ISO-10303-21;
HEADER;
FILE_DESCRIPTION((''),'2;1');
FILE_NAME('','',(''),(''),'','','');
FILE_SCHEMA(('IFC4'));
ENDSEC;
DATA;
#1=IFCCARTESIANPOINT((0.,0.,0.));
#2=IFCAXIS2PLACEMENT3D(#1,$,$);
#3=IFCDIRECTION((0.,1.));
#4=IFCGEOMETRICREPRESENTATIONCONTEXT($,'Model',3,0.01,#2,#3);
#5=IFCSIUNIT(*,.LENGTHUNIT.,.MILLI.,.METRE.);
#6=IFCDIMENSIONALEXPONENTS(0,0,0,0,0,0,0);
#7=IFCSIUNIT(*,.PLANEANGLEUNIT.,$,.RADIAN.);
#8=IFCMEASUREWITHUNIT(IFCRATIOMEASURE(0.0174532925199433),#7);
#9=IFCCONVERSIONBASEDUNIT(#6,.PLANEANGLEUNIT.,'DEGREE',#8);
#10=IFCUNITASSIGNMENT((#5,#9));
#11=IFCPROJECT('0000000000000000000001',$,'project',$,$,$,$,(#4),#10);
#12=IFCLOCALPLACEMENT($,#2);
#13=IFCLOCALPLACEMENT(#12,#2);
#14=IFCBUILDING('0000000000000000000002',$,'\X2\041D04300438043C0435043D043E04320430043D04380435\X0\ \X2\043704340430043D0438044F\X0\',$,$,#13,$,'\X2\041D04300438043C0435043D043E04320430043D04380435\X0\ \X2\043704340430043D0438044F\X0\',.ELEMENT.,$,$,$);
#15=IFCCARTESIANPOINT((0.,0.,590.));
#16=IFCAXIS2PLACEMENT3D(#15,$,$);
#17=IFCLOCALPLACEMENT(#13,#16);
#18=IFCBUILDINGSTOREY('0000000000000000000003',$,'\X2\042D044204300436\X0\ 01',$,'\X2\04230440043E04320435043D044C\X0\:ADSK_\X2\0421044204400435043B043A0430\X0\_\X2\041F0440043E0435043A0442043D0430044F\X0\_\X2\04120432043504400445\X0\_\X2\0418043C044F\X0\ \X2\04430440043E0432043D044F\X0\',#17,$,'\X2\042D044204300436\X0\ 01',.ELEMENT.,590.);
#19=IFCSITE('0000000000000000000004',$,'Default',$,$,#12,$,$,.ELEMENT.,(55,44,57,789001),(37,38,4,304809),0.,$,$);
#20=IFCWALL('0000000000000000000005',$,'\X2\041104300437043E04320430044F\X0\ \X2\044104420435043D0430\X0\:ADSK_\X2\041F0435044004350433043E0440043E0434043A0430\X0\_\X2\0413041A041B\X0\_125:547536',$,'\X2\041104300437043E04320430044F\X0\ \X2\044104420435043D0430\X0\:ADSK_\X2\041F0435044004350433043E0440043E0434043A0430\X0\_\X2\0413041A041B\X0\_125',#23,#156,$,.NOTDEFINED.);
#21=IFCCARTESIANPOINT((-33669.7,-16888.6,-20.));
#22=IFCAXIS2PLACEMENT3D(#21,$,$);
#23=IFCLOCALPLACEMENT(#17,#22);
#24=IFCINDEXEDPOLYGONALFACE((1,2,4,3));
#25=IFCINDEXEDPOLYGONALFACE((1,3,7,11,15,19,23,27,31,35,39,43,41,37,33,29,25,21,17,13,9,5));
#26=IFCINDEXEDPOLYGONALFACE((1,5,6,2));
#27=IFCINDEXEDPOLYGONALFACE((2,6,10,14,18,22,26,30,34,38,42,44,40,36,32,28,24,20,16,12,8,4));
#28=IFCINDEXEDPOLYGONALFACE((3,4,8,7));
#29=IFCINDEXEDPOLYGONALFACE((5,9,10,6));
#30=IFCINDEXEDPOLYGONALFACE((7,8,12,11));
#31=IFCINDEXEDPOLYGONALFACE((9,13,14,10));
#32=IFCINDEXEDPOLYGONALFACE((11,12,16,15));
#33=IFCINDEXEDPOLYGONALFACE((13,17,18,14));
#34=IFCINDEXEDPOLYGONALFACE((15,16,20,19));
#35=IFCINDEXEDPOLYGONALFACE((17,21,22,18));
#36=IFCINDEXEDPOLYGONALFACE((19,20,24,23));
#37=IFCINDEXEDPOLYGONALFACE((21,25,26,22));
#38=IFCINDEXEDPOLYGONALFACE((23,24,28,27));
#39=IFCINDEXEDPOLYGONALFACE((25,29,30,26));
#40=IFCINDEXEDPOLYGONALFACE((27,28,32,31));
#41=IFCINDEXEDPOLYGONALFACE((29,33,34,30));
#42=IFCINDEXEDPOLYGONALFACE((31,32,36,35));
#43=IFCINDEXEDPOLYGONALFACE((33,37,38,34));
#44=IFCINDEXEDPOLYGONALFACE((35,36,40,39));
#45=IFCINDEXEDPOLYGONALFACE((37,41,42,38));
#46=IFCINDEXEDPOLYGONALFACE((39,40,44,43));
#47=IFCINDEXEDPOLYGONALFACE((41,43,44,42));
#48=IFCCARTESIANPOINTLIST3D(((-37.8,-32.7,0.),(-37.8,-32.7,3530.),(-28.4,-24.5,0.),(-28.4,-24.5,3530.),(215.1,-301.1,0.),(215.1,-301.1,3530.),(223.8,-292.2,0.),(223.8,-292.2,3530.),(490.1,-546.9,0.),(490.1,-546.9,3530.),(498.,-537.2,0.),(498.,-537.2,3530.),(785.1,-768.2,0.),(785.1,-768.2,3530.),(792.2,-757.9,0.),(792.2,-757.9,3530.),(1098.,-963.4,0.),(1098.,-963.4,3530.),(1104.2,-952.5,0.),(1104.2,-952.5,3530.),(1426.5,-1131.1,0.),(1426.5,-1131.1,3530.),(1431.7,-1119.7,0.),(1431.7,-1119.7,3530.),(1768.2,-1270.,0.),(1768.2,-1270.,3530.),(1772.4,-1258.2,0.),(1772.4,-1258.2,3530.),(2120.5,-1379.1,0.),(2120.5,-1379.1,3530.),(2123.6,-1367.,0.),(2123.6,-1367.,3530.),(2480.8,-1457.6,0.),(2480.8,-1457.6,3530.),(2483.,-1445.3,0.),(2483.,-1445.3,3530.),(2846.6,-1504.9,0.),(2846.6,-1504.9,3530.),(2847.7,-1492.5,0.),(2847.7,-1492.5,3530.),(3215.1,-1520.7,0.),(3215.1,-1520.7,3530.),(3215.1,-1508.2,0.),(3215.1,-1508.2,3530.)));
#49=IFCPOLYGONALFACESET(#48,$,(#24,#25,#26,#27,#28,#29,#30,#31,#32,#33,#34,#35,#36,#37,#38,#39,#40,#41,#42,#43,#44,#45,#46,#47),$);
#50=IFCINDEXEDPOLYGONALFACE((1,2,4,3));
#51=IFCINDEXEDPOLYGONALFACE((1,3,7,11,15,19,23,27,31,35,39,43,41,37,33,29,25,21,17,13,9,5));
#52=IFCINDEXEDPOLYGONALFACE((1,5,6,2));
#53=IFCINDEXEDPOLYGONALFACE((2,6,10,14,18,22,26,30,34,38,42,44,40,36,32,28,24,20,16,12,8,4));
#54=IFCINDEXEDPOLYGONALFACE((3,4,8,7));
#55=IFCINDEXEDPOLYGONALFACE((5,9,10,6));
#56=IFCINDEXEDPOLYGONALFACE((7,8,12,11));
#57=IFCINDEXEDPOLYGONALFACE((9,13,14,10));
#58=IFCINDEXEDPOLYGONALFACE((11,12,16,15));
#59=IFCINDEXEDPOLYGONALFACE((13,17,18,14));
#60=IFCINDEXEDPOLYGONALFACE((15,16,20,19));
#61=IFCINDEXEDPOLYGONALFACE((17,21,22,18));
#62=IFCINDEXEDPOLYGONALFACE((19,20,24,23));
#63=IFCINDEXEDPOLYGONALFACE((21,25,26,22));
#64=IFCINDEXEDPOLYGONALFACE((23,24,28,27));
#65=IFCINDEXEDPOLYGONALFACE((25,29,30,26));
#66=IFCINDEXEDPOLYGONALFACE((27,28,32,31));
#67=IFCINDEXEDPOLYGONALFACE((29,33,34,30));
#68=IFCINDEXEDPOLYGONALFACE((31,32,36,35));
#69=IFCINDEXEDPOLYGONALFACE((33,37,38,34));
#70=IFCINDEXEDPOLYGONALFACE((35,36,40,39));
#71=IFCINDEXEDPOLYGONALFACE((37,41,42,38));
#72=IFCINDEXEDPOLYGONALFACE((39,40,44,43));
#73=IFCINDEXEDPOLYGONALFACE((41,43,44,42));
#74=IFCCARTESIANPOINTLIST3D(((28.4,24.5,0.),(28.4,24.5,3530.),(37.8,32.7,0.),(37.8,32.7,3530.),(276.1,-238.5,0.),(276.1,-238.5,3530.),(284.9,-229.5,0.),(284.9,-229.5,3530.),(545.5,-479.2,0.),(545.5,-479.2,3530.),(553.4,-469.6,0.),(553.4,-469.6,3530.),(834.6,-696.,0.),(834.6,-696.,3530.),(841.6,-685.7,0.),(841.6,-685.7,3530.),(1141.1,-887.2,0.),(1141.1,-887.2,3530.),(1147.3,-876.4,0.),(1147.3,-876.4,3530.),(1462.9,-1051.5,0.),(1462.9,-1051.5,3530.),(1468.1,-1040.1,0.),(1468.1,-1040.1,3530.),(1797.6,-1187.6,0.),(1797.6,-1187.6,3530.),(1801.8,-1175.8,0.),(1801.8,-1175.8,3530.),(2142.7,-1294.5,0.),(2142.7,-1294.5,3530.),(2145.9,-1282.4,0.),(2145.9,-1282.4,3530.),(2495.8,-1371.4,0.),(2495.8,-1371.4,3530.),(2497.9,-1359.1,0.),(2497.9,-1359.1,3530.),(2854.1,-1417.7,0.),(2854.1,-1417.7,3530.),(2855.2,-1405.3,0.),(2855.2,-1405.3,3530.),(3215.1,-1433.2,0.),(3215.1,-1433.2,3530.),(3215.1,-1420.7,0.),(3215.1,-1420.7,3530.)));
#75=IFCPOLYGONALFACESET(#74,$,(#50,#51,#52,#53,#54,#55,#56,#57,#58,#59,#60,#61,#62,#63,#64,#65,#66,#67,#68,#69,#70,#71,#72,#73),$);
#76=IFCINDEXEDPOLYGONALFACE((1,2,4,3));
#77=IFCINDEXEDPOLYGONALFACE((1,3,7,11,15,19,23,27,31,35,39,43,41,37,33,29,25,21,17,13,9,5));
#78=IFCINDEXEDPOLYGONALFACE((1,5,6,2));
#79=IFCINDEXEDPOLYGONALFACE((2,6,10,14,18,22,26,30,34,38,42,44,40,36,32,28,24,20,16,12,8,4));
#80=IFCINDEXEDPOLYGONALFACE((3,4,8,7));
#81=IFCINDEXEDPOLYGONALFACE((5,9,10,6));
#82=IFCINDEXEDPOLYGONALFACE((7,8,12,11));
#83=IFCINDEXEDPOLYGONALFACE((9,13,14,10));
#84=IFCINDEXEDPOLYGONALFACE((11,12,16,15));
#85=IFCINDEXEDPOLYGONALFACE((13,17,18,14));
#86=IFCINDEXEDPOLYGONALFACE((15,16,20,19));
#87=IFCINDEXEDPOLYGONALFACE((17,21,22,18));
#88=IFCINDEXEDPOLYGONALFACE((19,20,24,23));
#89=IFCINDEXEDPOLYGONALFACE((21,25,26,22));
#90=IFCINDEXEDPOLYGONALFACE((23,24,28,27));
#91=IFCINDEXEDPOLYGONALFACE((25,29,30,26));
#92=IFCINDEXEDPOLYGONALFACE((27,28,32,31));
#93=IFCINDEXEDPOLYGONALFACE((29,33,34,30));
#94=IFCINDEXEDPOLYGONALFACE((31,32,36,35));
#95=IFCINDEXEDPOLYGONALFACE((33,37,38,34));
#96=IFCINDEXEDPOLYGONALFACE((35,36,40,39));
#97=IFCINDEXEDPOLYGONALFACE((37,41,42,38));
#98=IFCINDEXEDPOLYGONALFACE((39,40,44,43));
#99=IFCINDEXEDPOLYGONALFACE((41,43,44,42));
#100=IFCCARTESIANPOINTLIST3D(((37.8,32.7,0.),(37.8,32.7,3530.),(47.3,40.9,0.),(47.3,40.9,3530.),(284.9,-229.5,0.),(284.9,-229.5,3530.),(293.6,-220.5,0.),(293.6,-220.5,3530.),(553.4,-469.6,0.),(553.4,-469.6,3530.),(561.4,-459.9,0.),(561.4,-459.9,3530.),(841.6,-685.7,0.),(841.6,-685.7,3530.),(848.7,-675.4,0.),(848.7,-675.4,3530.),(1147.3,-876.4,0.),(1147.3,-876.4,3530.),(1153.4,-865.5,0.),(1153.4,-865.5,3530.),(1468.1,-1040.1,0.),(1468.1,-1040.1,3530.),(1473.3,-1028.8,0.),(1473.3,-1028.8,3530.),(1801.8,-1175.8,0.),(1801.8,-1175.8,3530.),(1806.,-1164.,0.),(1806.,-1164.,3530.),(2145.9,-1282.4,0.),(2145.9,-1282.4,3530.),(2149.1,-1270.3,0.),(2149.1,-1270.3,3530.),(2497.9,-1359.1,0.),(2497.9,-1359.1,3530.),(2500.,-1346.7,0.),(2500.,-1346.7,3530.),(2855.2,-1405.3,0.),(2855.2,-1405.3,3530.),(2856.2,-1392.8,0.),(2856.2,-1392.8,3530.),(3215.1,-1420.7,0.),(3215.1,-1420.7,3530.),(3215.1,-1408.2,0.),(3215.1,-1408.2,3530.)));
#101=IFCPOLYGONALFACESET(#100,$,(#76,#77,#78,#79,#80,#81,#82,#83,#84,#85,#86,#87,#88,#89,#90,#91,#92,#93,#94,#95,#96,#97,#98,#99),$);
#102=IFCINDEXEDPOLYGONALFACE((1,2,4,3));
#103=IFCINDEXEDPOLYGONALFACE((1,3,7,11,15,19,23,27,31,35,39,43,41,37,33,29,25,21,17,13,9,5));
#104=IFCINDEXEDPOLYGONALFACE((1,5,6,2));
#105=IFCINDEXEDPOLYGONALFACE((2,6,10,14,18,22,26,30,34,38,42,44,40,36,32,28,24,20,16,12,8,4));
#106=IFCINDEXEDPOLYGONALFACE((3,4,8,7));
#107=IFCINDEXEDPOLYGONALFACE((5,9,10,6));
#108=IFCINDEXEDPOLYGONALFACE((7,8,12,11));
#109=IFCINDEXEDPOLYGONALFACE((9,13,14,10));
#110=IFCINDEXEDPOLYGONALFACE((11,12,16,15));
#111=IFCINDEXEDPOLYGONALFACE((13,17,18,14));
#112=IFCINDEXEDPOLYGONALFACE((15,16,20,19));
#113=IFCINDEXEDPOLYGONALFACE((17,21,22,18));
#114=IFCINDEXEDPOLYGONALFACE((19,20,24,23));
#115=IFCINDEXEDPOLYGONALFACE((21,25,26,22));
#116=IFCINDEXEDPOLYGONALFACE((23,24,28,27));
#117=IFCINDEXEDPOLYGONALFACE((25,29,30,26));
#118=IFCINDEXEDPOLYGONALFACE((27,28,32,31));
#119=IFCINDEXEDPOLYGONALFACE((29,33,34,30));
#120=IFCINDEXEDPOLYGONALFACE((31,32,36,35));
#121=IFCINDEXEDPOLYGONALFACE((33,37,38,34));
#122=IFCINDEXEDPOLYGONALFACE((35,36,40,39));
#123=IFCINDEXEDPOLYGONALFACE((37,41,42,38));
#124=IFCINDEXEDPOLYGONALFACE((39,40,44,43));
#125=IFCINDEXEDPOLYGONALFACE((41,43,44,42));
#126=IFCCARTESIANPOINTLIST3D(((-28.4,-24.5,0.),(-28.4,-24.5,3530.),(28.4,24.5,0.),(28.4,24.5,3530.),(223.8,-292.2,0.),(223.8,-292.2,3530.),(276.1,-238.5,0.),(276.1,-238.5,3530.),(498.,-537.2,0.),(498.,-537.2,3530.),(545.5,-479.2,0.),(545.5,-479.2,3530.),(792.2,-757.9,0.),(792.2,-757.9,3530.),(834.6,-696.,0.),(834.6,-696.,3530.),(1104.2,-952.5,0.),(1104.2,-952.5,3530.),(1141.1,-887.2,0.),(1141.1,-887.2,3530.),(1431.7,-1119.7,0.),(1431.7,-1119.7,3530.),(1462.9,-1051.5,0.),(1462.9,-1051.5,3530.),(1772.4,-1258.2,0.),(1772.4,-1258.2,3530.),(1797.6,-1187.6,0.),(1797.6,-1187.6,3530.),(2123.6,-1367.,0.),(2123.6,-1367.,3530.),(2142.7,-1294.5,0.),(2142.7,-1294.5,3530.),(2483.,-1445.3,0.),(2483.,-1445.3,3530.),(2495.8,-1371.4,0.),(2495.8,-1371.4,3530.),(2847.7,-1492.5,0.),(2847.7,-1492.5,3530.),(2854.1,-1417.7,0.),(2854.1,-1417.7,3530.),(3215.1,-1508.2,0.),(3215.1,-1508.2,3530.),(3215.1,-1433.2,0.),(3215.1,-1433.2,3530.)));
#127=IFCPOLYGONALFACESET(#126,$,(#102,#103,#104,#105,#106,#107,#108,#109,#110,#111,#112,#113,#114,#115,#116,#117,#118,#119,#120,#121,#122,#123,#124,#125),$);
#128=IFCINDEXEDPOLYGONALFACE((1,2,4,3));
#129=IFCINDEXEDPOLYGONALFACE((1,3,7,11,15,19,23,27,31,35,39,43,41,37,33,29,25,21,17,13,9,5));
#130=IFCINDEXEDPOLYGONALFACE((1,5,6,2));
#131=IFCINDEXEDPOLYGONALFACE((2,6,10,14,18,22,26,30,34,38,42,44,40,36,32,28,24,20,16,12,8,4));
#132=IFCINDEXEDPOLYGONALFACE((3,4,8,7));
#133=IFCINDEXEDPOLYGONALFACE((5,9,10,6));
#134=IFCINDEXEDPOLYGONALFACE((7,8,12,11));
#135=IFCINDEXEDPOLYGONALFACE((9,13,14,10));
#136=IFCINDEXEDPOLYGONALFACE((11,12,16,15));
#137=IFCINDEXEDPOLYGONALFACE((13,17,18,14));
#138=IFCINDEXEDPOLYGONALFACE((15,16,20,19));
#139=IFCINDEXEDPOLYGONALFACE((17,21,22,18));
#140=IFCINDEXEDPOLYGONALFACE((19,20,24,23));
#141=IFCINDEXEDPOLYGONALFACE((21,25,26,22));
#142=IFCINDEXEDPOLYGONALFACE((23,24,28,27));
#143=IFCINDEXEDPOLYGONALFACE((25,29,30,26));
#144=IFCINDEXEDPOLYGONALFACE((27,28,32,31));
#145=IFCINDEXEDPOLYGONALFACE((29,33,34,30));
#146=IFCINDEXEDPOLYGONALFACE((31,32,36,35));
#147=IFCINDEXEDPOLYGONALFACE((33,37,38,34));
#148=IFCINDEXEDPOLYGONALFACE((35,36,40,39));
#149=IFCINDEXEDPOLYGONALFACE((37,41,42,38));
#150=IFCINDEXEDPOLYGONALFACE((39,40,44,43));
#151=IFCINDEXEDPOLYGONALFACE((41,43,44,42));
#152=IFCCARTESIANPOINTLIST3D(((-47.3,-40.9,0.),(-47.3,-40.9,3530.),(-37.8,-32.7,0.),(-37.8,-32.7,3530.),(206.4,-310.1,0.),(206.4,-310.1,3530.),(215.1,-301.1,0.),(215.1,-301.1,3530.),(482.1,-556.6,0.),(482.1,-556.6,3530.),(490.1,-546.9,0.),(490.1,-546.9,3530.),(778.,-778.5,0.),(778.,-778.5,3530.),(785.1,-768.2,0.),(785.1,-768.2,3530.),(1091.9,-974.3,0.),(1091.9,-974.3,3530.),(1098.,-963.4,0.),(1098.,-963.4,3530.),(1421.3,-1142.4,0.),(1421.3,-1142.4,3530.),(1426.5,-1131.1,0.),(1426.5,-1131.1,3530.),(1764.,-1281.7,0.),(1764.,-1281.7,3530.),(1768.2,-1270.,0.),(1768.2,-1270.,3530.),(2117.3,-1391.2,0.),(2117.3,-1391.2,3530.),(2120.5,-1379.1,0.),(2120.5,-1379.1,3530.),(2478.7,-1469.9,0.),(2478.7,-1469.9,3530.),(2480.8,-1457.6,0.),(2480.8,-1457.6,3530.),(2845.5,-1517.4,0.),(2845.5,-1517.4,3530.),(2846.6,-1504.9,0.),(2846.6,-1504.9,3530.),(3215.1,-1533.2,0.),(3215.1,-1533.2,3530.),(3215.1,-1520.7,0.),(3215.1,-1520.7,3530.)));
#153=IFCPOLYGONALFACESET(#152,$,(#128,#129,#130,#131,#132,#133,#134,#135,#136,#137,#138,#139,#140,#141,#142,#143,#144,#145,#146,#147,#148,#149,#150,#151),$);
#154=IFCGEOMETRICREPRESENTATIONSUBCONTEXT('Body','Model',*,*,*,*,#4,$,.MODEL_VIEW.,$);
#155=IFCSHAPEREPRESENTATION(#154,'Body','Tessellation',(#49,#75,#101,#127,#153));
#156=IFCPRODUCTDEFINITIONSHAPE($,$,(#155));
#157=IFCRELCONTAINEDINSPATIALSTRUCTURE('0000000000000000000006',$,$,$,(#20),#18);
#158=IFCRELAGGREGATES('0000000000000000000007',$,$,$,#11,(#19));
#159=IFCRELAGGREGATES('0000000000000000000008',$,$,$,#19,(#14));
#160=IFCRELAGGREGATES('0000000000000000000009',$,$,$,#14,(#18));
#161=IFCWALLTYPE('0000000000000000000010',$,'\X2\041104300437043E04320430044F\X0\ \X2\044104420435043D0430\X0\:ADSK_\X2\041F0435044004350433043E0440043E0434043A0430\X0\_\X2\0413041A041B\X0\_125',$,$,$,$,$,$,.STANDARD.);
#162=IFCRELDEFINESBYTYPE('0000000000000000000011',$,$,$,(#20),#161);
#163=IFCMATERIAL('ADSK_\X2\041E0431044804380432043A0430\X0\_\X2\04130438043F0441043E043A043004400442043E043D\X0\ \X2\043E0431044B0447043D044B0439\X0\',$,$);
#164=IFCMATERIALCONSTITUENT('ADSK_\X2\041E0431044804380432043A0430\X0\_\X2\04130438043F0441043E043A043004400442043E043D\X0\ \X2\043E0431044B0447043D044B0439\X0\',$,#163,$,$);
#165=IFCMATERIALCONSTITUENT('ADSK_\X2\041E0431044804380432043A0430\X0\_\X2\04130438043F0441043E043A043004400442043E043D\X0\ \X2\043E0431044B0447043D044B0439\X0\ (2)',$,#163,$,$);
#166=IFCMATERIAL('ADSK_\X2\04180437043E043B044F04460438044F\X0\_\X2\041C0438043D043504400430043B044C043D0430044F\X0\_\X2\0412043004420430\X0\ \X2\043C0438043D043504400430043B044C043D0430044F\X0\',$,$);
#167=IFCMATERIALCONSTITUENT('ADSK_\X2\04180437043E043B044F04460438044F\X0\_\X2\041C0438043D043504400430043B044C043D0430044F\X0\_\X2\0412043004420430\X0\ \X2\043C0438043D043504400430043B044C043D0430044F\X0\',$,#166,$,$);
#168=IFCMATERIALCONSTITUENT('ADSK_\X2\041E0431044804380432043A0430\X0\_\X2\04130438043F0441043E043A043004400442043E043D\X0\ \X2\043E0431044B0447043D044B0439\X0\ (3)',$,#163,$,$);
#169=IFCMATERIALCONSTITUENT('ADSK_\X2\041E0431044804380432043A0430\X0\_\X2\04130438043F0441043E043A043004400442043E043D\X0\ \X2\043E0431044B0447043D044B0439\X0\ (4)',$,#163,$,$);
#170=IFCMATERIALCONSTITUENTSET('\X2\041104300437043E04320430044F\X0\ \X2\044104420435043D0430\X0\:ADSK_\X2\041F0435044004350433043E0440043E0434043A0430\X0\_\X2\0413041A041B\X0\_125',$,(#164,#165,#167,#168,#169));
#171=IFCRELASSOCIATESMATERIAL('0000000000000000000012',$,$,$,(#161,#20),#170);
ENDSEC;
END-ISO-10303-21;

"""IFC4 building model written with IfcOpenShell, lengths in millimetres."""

from ifc_helpers import new_model, entity, si_unit, converted_unit, direction, frame, origin, place, context, subcontext, project, spatial, indexed_curve, outline, extrude, material, constituent, constituent_set, type_object, element, save


model = new_model("IFC4")

# Units and contexts
model_context = context("Model", 3, precision=0.01, world=origin(), true_north=direction((0.0, 1.0)))
body_context = subcontext(model_context, "Body", "Model", "MODEL_VIEW")
ifc_project = project(units=[si_unit("LENGTHUNIT", "METRE", prefix="MILLI"), converted_unit("PLANEANGLEUNIT", "DEGREE", entity("IfcRatioMeasure", 0.0174532925199433), si_unit("PLANEANGLEUNIT", "RADIAN"), dimensions=[0, 0, 0, 0, 0, 0, 0])], contexts=[model_context])

# Site, building, storey
site_placement = place(None, origin())
site = spatial("IfcSite", under=ifc_project, at=site_placement, Name="Default", CompositionType="ELEMENT", RefLatitude=(55, 44, 57, 789001), RefLongitude=(37, 38, 4, 304809), RefElevation=0.0)
building_placement = place(site_placement, origin())
building = spatial("IfcBuilding", under=site, at=building_placement, Name="Наименование здания", LongName="Наименование здания", CompositionType="ELEMENT")
storey_placement = place(building_placement, frame((0.0, 0.0, 590.0)))
storey = spatial("IfcBuildingStorey", under=building, at=storey_placement, Name="Этаж 01", ObjectType="Уровень:ADSK_Стрелка_Проектная_Вверх_Имя уровня", LongName="Этаж 01", CompositionType="ELEMENT", Elevation=590.0)

# Wall
ifc_material_1 = material(Name="ADSK_Обшивка_Гипсокартон обычный")
ifc_constituent_1 = constituent(ifc_material_1, Name="ADSK_Обшивка_Гипсокартон обычный")
ifc_constituent_2 = constituent(ifc_material_1, Name="ADSK_Обшивка_Гипсокартон обычный (2)")
ifc_material_2 = material(Name="ADSK_Изоляция_Минеральная_Вата минеральная")
ifc_constituent_3 = constituent(ifc_material_2, Name="ADSK_Изоляция_Минеральная_Вата минеральная")
ifc_constituent_4 = constituent(ifc_material_1, Name="ADSK_Обшивка_Гипсокартон обычный (3)")
ifc_constituent_5 = constituent(ifc_material_1, Name="ADSK_Обшивка_Гипсокартон обычный (4)")
ifc_constituent_set = constituent_set(constituents=[ifc_constituent_1, ifc_constituent_2, ifc_constituent_3, ifc_constituent_4, ifc_constituent_5], Name="Базовая стена:ADSK_Перегородка_ГКЛ_125")
wall_type_1 = type_object("IfcWallType", Name="Базовая стена:ADSK_Перегородка_ГКЛ_125", PredefinedType="STANDARD", material=ifc_constituent_set)
wall_1_placement = place(storey_placement, frame((-33669.7, -16888.6, -20.0)))
element("IfcWall", 1, at=wall_1_placement, inside=storey, type_object=wall_type_1, material=ifc_constituent_set, Name="Базовая стена:ADSK_Перегородка_ГКЛ_125:547536", ObjectType="Базовая стена:ADSK_Перегородка_ГКЛ_125", PredefinedType="NOTDEFINED", context=body_context, shape_type="SweptSolid", body=[
    extrude(outline(indexed_curve([(-763.9, -1611.5), (-755.8, -1621.0), (-484.7, -1370.9), (-236.1, -1098.5), (-11.7, -805.8), (186.7, -494.9), (357.8, -168.2), (500.2, 172.0), (613.0, 523.1), (695.3, 882.7), (746.4, 1247.9), (766.1, 1616.2), (753.6, 1616.3), (734.0, 1249.1), (683.0, 884.9), (601.0, 526.4), (488.5, 176.3), (346.5, -162.9), (175.9, -488.7), (-22.0, -798.6), (-245.7, -1090.5), (-493.6, -1362.1), (-763.9, -1611.5)], self_intersect=False)), frame((1591.0, -771.5, 0.0), z_axis=(0.0, 0.0, -1.0), x_axis=(-0.763353, -0.645981, 0.0)), (0.0, 0.0, -1.0), 3530.0),
    extrude(outline(indexed_curve([(-748.4, -1578.5), (-740.3, -1588.1), (-474.8, -1343.1), (-231.2, -1076.2), (-11.4, -789.4), (183.0, -484.9), (350.6, -164.8), (490.2, 168.4), (600.6, 512.4), (681.2, 864.6), (731.3, 1222.5), (750.6, 1583.2), (738.1, 1583.4), (718.9, 1223.7), (668.9, 866.9), (588.6, 515.7), (478.4, 172.8), (339.3, -159.5), (172.2, -478.6), (-21.6, -782.3), (-240.8, -1068.2), (-483.6, -1334.3), (-748.4, -1578.5)], self_intersect=False)), frame((1624.1, -699.2, 0.0), z_axis=(0.0, 0.0, -1.0), x_axis=(-0.763353, -0.645981, 0.0)), (0.0, 0.0, -1.0), 3530.0),
    extrude(outline(indexed_curve([(719.4, 1586.2), (704.0, 1227.4), (657.9, 871.2), (581.4, 520.3), (475.2, 177.2), (339.9, -155.5), (176.6, -475.4), (-13.5, -780.1), (-229.0, -1067.4), (-468.3, -1335.2), (-729.7, -1581.5), (-721.5, -1591.0), (-459.4, -1343.9), (-219.3, -1075.4), (-3.1, -787.2), (187.5, -481.5), (351.3, -160.7), (486.9, 173.0), (593.5, 517.1), (670.2, 869.1), (716.4, 1226.3), (731.9, 1586.2), (719.4, 1586.2)], self_intersect=False)), frame((1628.8, -688.9, 0.0), z_axis=(0.0, 0.0, -1.0), x_axis=(-0.756583, -0.653898, 0.0)), (0.0, 0.0, -1.0), 3530.0),
    extrude(outline(indexed_curve([(-776.3, -1571.2), (-727.9, -1628.4), (-457.6, -1379.0), (-209.7, -1107.4), (14.0, -815.6), (211.9, -505.6), (382.5, -179.8), (524.5, 159.4), (637.0, 509.5), (719.0, 868.0), (770.0, 1232.2), (789.6, 1599.4), (714.6, 1600.2), (695.3, 1239.4), (645.2, 881.6), (564.6, 529.4), (454.2, 185.4), (314.6, -147.9), (147.0, -468.0), (-47.4, -772.5), (-267.2, -1059.3), (-510.8, -1326.1), (-776.3, -1571.2)], self_intersect=False)), frame((1607.5, -735.4, 0.0), z_axis=(0.0, 0.0, -1.0), x_axis=(-0.763353, -0.645981, 0.0)), (0.0, 0.0, -1.0), 3530.0),
    extrude(outline(indexed_curve([(-751.4, -1628.8), (-738.9, -1628.8), (-723.0, -1260.3), (-675.7, -894.6), (-597.2, -534.2), (-488.1, -181.9), (-349.2, 159.7), (-181.5, 488.2), (13.7, 801.1), (235.0, 1096.2), (480.8, 1371.2), (749.2, 1624.1), (741.0, 1633.5), (471.8, 1379.9), (225.3, 1104.1), (3.4, 808.2), (-192.4, 494.4), (-360.6, 164.9), (-499.9, -177.7), (-609.3, -531.0), (-688.0, -892.4), (-735.5, -1259.3), (-751.4, -1628.8)], self_intersect=False)), frame((1586.2, -781.9, 0.0), z_axis=(0.0, 0.0, 1.0), x_axis=(0.0, 1.0, 0.0)), (0.0, 0.0, 1.0), 3530.0),
])

save(model, "model.ifc")
